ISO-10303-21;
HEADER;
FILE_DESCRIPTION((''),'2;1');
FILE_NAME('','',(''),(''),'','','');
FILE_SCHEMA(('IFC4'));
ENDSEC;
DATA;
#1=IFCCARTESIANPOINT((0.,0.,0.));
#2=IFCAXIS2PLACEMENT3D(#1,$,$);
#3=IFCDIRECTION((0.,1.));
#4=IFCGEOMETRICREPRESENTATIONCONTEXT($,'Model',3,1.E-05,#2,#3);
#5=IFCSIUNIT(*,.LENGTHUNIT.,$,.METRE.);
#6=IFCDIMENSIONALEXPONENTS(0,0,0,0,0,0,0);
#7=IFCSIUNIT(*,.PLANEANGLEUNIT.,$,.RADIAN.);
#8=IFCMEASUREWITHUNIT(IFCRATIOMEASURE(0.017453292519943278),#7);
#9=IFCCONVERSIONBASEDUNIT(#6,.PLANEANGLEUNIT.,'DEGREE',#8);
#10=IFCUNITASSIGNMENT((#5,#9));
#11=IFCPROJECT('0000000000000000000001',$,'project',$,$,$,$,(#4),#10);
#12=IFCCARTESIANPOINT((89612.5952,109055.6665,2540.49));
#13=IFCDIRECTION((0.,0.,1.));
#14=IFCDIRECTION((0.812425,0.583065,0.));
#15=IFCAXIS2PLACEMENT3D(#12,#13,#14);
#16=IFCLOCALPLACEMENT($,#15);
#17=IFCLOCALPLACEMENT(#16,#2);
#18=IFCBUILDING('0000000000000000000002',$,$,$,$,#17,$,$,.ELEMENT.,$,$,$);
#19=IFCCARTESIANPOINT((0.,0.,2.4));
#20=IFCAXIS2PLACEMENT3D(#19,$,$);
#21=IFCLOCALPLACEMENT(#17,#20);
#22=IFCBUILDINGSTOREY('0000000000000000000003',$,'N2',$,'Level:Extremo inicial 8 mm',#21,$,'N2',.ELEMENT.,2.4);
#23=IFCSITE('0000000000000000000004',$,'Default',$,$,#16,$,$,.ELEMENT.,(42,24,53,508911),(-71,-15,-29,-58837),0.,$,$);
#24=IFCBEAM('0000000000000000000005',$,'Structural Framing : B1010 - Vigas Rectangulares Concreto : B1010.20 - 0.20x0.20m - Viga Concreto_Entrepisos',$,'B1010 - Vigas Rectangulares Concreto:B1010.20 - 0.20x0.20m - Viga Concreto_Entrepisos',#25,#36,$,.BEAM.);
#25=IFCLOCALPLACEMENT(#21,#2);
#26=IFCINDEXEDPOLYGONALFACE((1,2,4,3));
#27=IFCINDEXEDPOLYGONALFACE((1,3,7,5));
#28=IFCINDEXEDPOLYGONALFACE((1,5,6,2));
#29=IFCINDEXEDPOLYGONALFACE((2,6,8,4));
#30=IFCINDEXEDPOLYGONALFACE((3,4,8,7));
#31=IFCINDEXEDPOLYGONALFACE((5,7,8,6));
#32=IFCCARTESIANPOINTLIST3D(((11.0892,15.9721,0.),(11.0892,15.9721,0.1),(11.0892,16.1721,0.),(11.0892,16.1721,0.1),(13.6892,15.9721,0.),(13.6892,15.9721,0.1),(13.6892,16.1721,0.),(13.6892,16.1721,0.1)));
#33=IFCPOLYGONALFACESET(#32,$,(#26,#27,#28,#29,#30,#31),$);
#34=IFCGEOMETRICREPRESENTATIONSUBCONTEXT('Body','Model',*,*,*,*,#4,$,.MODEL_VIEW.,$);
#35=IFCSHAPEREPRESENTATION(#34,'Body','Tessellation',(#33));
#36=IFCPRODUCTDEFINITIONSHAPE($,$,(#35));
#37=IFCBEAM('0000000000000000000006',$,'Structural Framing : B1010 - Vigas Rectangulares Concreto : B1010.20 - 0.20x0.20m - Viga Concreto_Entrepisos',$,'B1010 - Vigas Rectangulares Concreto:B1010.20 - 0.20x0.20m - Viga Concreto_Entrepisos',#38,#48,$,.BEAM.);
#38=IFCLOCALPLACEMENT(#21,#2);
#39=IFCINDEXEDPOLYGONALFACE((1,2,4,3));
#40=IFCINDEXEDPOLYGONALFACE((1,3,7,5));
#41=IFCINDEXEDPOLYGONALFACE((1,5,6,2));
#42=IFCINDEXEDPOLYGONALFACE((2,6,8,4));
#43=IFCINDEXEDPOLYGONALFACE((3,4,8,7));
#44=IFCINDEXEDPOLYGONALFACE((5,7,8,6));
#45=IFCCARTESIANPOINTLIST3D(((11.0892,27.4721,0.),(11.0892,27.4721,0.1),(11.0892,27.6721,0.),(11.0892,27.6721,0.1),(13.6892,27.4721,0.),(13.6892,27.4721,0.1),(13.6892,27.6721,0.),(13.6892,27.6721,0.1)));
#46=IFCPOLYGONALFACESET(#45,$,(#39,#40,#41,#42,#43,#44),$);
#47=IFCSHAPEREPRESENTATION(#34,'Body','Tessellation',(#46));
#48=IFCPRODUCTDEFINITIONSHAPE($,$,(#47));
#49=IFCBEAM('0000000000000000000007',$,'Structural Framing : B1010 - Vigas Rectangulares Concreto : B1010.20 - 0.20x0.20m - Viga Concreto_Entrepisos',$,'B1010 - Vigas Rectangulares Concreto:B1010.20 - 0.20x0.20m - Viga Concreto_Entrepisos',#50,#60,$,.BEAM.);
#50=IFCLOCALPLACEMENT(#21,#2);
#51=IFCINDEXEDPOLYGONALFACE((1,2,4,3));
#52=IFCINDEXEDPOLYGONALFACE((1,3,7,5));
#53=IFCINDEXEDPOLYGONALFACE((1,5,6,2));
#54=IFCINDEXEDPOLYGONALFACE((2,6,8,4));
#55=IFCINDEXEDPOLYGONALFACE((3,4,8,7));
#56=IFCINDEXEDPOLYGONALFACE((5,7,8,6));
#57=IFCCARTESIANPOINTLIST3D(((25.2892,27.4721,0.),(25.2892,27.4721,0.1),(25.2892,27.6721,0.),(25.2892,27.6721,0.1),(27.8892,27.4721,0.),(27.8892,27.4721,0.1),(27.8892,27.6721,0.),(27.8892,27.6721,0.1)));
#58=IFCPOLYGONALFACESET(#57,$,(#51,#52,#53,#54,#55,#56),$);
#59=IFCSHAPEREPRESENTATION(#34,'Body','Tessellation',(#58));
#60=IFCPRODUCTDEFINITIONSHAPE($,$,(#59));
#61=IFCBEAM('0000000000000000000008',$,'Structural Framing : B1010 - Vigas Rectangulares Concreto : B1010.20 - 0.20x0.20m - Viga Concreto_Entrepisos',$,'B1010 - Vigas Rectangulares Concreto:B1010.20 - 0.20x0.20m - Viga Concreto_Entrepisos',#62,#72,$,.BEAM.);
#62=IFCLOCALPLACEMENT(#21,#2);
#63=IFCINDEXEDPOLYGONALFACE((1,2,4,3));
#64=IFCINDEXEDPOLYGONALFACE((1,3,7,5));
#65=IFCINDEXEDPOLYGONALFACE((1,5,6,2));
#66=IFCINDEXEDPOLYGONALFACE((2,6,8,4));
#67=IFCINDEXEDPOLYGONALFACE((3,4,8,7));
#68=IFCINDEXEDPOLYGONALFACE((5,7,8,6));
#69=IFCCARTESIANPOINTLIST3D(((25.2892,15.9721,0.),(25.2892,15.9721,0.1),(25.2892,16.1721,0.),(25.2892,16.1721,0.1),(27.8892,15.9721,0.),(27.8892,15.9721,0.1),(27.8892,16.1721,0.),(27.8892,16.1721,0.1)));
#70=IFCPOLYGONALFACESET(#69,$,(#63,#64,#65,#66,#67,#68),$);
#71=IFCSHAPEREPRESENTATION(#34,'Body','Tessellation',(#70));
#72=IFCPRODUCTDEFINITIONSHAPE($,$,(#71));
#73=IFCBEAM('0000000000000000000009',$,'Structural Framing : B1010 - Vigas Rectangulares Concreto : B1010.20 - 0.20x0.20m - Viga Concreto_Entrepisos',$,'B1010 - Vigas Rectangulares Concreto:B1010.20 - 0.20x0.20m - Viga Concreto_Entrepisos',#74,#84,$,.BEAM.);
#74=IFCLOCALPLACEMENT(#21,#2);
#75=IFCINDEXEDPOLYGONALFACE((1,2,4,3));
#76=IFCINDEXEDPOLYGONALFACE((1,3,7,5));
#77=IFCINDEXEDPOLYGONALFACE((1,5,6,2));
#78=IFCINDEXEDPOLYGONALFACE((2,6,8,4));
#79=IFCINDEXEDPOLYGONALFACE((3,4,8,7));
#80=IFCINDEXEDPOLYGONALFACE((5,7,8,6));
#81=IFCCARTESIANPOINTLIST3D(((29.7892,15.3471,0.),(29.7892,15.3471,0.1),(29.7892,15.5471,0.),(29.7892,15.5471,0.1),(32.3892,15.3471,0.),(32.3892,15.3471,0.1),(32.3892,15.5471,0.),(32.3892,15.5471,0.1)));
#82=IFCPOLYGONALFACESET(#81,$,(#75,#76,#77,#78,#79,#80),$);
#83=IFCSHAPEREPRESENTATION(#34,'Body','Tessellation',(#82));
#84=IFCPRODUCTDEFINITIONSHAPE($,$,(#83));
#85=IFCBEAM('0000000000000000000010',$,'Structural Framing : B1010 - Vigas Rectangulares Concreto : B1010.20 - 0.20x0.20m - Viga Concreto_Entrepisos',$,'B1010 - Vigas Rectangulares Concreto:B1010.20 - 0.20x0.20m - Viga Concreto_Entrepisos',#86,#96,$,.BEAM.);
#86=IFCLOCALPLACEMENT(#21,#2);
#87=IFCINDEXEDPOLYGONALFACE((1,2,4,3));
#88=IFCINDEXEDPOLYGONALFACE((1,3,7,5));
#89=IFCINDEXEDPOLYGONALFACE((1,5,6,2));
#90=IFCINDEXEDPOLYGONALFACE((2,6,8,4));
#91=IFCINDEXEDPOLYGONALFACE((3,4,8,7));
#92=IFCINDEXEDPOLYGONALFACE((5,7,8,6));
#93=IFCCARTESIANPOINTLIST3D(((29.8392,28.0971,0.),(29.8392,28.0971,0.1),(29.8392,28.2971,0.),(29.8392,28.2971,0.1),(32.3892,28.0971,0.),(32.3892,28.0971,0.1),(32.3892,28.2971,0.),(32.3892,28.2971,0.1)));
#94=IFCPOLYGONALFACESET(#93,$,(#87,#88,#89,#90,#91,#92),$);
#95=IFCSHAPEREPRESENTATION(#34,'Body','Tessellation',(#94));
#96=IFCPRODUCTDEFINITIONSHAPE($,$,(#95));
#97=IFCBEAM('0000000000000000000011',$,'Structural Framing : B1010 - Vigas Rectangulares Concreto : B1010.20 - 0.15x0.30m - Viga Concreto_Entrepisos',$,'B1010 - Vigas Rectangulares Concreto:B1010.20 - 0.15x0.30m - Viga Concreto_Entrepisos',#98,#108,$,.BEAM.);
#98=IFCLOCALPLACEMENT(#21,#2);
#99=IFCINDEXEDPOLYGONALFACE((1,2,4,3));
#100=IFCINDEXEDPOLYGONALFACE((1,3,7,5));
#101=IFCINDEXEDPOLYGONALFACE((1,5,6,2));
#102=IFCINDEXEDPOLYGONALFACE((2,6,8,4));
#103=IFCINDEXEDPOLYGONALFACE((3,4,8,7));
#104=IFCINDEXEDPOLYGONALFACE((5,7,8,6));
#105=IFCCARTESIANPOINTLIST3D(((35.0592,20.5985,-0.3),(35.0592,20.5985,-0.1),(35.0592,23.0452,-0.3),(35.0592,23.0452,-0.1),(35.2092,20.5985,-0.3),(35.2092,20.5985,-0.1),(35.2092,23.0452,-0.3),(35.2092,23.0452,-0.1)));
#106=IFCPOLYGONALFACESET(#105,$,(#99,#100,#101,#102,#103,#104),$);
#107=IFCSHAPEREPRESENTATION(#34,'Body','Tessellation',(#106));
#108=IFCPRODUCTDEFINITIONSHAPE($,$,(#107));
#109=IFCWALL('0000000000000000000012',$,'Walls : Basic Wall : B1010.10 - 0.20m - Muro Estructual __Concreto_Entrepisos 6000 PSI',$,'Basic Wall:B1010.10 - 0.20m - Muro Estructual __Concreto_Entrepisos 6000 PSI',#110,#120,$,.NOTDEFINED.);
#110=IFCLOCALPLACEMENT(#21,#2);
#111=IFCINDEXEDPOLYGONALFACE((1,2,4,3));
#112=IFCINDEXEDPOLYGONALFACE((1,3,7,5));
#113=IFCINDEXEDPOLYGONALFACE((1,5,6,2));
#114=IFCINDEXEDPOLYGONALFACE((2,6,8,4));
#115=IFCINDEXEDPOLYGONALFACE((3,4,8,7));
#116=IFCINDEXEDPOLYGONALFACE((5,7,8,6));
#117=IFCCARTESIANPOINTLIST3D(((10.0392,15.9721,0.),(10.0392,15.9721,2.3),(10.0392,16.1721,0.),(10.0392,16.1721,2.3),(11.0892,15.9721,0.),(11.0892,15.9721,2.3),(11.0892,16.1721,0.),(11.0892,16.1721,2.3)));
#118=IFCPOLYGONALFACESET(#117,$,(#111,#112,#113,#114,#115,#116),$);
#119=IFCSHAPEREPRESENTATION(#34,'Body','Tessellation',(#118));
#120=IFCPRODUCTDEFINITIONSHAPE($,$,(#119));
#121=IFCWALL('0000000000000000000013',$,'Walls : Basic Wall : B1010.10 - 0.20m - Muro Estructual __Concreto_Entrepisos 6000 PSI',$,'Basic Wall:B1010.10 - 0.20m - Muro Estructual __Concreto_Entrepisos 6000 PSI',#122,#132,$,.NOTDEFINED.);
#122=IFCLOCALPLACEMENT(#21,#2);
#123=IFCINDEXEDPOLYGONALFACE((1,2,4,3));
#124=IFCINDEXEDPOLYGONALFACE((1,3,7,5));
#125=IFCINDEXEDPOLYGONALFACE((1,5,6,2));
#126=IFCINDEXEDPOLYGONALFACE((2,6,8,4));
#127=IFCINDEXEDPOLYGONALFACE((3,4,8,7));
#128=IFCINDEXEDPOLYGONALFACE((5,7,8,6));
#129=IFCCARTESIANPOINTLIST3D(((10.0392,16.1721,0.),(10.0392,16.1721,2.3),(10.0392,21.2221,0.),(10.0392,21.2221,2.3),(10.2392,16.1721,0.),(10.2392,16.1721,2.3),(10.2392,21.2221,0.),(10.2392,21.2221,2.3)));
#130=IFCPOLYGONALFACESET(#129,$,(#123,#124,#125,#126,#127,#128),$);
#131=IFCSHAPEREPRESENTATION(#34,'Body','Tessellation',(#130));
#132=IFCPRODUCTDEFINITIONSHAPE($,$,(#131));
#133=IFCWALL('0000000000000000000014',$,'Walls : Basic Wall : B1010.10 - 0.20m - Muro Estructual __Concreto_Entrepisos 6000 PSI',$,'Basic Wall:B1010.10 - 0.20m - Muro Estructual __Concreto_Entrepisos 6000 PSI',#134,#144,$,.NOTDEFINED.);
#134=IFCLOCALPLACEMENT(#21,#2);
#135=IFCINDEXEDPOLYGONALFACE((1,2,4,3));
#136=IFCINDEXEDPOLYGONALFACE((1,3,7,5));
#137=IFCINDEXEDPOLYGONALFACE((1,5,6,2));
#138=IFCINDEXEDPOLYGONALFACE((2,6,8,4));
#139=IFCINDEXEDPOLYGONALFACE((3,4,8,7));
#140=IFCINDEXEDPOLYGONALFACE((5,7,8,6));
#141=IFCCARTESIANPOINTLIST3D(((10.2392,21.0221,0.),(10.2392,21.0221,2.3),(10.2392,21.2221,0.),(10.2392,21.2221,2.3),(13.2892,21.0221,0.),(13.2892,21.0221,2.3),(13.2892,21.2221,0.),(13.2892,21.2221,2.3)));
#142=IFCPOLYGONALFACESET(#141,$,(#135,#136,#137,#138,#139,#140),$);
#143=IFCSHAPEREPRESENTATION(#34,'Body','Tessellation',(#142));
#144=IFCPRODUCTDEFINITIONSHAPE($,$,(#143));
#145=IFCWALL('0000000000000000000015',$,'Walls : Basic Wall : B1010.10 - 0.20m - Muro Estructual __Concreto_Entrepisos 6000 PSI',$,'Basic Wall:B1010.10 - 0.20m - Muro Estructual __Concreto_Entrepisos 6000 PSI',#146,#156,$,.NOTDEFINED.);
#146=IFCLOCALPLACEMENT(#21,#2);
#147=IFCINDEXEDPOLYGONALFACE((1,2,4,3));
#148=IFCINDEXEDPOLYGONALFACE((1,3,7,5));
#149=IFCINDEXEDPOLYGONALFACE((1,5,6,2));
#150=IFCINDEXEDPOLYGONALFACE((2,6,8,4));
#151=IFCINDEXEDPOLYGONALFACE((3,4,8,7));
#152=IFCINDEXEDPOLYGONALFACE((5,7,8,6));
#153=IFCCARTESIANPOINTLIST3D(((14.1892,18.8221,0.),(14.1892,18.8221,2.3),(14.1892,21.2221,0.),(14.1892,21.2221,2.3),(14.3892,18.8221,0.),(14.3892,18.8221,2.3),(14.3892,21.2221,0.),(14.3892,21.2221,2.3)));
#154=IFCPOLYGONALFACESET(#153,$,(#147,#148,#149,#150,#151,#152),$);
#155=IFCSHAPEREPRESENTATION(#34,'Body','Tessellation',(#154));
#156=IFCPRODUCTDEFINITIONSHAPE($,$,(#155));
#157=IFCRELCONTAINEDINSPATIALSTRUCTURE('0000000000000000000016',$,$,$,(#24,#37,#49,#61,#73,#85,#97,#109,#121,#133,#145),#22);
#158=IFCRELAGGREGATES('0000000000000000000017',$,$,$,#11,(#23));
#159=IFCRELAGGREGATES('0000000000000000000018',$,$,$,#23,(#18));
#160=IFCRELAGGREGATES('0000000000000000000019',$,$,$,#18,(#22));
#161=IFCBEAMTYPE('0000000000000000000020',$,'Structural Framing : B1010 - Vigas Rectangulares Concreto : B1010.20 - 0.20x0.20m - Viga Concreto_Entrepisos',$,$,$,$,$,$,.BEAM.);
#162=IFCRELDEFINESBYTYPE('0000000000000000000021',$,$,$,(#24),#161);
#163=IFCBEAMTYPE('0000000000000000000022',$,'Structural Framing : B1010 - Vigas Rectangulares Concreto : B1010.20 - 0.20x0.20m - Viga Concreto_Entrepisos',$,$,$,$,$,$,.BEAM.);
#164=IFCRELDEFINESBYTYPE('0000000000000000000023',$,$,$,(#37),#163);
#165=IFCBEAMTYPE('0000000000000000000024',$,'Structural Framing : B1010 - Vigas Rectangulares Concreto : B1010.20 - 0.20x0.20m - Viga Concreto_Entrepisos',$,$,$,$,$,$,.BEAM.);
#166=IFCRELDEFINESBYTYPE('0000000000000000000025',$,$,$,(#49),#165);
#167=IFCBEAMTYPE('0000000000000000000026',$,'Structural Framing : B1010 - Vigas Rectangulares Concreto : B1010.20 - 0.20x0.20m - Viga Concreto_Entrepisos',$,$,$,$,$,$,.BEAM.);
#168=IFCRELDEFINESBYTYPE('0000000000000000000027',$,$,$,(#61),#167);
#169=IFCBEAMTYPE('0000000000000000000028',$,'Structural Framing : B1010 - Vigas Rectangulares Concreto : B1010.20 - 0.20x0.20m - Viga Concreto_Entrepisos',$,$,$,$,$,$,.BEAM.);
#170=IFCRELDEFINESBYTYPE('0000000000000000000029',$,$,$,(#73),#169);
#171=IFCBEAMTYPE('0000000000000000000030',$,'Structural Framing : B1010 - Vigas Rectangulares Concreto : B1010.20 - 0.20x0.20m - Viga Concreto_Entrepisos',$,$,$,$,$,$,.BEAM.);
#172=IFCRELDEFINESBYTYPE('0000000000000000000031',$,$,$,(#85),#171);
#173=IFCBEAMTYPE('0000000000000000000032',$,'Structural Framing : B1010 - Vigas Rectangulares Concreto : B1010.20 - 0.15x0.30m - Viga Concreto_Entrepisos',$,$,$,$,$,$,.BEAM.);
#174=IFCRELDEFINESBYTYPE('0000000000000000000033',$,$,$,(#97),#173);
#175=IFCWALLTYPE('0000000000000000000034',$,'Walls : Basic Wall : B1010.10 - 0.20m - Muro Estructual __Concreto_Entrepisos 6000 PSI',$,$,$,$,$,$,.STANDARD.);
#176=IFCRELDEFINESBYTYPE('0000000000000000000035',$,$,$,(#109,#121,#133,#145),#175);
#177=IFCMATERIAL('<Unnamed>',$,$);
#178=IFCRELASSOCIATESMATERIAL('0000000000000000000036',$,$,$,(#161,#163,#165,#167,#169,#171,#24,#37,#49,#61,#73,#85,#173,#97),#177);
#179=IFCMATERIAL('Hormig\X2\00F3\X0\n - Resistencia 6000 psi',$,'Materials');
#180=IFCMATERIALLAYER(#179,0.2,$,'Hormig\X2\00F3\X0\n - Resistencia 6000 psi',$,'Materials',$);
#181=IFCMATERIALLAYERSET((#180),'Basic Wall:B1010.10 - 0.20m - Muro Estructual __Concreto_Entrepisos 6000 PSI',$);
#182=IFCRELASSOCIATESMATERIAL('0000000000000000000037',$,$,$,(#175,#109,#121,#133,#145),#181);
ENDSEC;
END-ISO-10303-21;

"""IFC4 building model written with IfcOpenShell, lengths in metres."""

from ifc_helpers import new_model, entity, si_unit, converted_unit, direction, frame, frame_2d, origin, place, context, subcontext, project, spatial, polyline, segment, composite_curve, rectangle, outline, extrude, source, transform, mapped, material, layer, layer_set, layer_usage, material_profile, profile_set, profile_usage, type_object, type_shapes, element, save


model = new_model("IFC4")

# Units and contexts
model_context = context("Model", 3, precision=1e-05, world=origin(), true_north=direction((0.0, 1.0)))
body_context = subcontext(model_context, "Body", "Model", "MODEL_VIEW")
ifc_project = project(units=[si_unit("LENGTHUNIT", "METRE"), converted_unit("PLANEANGLEUNIT", "DEGREE", entity("IfcRatioMeasure", 0.017453292519943278), si_unit("PLANEANGLEUNIT", "RADIAN"), dimensions=[0, 0, 0, 0, 0, 0, 0])], contexts=[model_context])

# Site, building, storey
site_placement = place(None, frame((89612.5952, 109055.6665, 2540.49), z_axis=(0.0, 0.0, 1.0), x_axis=(0.812425, 0.583065, 0.0)))
site = spatial("IfcSite", under=ifc_project, at=site_placement, Name="Default", CompositionType="ELEMENT", RefLatitude=(42, 24, 53, 508911), RefLongitude=(-71, -15, -29, -58837), RefElevation=0.0)
building_placement = place(site_placement, origin())
building = spatial("IfcBuilding", under=site, at=building_placement, CompositionType="ELEMENT")
storey_placement = place(building_placement, frame((0.0, 0.0, 2.4)))
storey = spatial("IfcBuildingStorey", under=building, at=storey_placement, Name="N2", ObjectType="Level:Extremo inicial 8 mm", LongName="N2", CompositionType="ELEMENT", Elevation=2.4)

# Beams
ifc_material_1 = material(Name="<Unnamed>")
ifc_material_profile_1 = material_profile(ifc_material_1, outline(composite_curve([segment(polyline([(-0.1, 0.0, 0.0), (-0.1, 0.1, 0.0)]), True, "CONTINUOUS"), segment(polyline([(-0.1, 0.1, 0.0), (0.1, 0.1, 0.0)]), True, "CONTINUOUS"), segment(polyline([(0.1, 0.1, 0.0), (0.1, 0.0, 0.0)]), True, "CONTINUOUS"), segment(polyline([(0.1, 0.0, 0.0), (-0.1, 0.0, 0.0)]), True, "CONTINUOUS")], self_intersect=False), kind="CURVE"), Name="B1010.20 - 0.20x0.20m - Viga Concreto_Entrepisos")
ifc_material_profile_2 = material_profile(ifc_material_1, outline(composite_curve([segment(polyline([(-1.3, -0.1, 0.1), (-1.3, 0.1, 0.1)]), True, "CONTINUOUS"), segment(polyline([(-1.3, 0.1, 0.1), (-1.3, 0.1, -0.1)]), True, "CONTINUOUS"), segment(polyline([(-1.3, 0.1, -0.1), (-1.3, -0.1, -0.1)]), True, "CONTINUOUS"), segment(polyline([(-1.3, -0.1, -0.1), (-1.3, -0.1, 0.1)]), True, "CONTINUOUS")], self_intersect=False), kind="CURVE"), Name="B1010.20 - 0.20x0.20m - Viga Concreto_Entrepisos")
ifc_profile_set_1 = profile_set([ifc_material_profile_1, ifc_material_profile_2], Name="B1010.20 - 0.20x0.20m - Viga Concreto_Entrepisos")
ifc_profile_usage_1 = profile_usage(ifc_profile_set_1, cardinal=8)
beam_type_1 = type_object("IfcBeamType", Name="Structural Framing : B1010 - Vigas Rectangulares Concreto : B1010.20 - 0.20x0.20m - Viga Concreto_Entrepisos", PredefinedType="BEAM", material=ifc_profile_set_1)
shared_shape_1 = source(origin(), body_context, "Body", "SweptSolid", [
    extrude(rectangle(XDim=0.1, YDim=0.2, at=frame_2d((0.0, 0.0), x_axis=(1.0, 0.0))), frame((13.6892, 16.0721, 2.45), z_axis=(-1.0, 0.0, 0.0), x_axis=(0.0, 0.0, -1.0)), (0.0, 0.0, 1.0), 2.6),
])
type_shapes(beam_type_1, [shared_shape_1])
beam_1_placement = place(storey_placement, frame((0.0, 0.0, -2.4)))
element("IfcBeam", 1, at=beam_1_placement, inside=storey, type_object=beam_type_1, material=ifc_profile_usage_1, Name="Structural Framing : B1010 - Vigas Rectangulares Concreto : B1010.20 - 0.20x0.20m - Viga Concreto_Entrepisos", ObjectType="B1010 - Vigas Rectangulares Concreto:B1010.20 - 0.20x0.20m - Viga Concreto_Entrepisos", PredefinedType="BEAM", context=body_context, shape_type="MappedRepresentation", body=[
    mapped(shared_shape_1, transform((0.0, 0.0, 0.0), scale=1.0)),
])
ifc_profile_usage_2 = profile_usage(ifc_profile_set_1, cardinal=8)
beam_type_2 = type_object("IfcBeamType", Name="Structural Framing : B1010 - Vigas Rectangulares Concreto : B1010.20 - 0.20x0.20m - Viga Concreto_Entrepisos", PredefinedType="BEAM", material=ifc_profile_set_1)
shared_shape_2 = source(origin(), body_context, "Body", "SweptSolid", [
    extrude(rectangle(XDim=0.1, YDim=0.2, at=frame_2d((0.0, 0.0), x_axis=(1.0, 0.0))), frame((13.6892, 27.5721, 2.45), z_axis=(-1.0, 0.0, 0.0), x_axis=(0.0, 0.0, -1.0)), (0.0, 0.0, 1.0), 2.6),
])
type_shapes(beam_type_2, [shared_shape_2])
beam_2_placement = place(storey_placement, frame((0.0, 0.0, -2.4)))
element("IfcBeam", 2, at=beam_2_placement, inside=storey, type_object=beam_type_2, material=ifc_profile_usage_2, Name="Structural Framing : B1010 - Vigas Rectangulares Concreto : B1010.20 - 0.20x0.20m - Viga Concreto_Entrepisos", ObjectType="B1010 - Vigas Rectangulares Concreto:B1010.20 - 0.20x0.20m - Viga Concreto_Entrepisos", PredefinedType="BEAM", context=body_context, shape_type="MappedRepresentation", body=[
    mapped(shared_shape_2, transform((0.0, 0.0, 0.0), scale=1.0)),
])
ifc_profile_usage_3 = profile_usage(ifc_profile_set_1, cardinal=8)
beam_type_3 = type_object("IfcBeamType", Name="Structural Framing : B1010 - Vigas Rectangulares Concreto : B1010.20 - 0.20x0.20m - Viga Concreto_Entrepisos", PredefinedType="BEAM", material=ifc_profile_set_1)
shared_shape_3 = source(origin(), body_context, "Body", "SweptSolid", [
    extrude(rectangle(XDim=0.1, YDim=0.2, at=frame_2d((0.0, 0.0), x_axis=(1.0, 0.0))), frame((25.2892, 27.5721, 2.45), z_axis=(1.0, 0.0, 0.0), x_axis=(0.0, 0.0, -1.0)), (0.0, 0.0, 1.0), 2.6),
])
type_shapes(beam_type_3, [shared_shape_3])
beam_3_placement = place(storey_placement, frame((0.0, 0.0, -2.4)))
element("IfcBeam", 3, at=beam_3_placement, inside=storey, type_object=beam_type_3, material=ifc_profile_usage_3, Name="Structural Framing : B1010 - Vigas Rectangulares Concreto : B1010.20 - 0.20x0.20m - Viga Concreto_Entrepisos", ObjectType="B1010 - Vigas Rectangulares Concreto:B1010.20 - 0.20x0.20m - Viga Concreto_Entrepisos", PredefinedType="BEAM", context=body_context, shape_type="MappedRepresentation", body=[
    mapped(shared_shape_3, transform((0.0, 0.0, 0.0), scale=1.0)),
])
ifc_profile_usage_4 = profile_usage(ifc_profile_set_1, cardinal=8)
beam_type_4 = type_object("IfcBeamType", Name="Structural Framing : B1010 - Vigas Rectangulares Concreto : B1010.20 - 0.20x0.20m - Viga Concreto_Entrepisos", PredefinedType="BEAM", material=ifc_profile_set_1)
shared_shape_4 = source(origin(), body_context, "Body", "SweptSolid", [
    extrude(rectangle(XDim=0.1, YDim=0.2, at=frame_2d((0.0, 0.0), x_axis=(1.0, 0.0))), frame((25.2892, 16.0721, 2.45), z_axis=(1.0, 0.0, 0.0), x_axis=(0.0, 0.0, -1.0)), (0.0, 0.0, 1.0), 2.6),
])
type_shapes(beam_type_4, [shared_shape_4])
beam_4_placement = place(storey_placement, frame((0.0, 0.0, -2.4)))
element("IfcBeam", 4, at=beam_4_placement, inside=storey, type_object=beam_type_4, material=ifc_profile_usage_4, Name="Structural Framing : B1010 - Vigas Rectangulares Concreto : B1010.20 - 0.20x0.20m - Viga Concreto_Entrepisos", ObjectType="B1010 - Vigas Rectangulares Concreto:B1010.20 - 0.20x0.20m - Viga Concreto_Entrepisos", PredefinedType="BEAM", context=body_context, shape_type="MappedRepresentation", body=[
    mapped(shared_shape_4, transform((0.0, 0.0, 0.0), scale=1.0)),
])
ifc_profile_usage_5 = profile_usage(ifc_profile_set_1, cardinal=8)
beam_type_5 = type_object("IfcBeamType", Name="Structural Framing : B1010 - Vigas Rectangulares Concreto : B1010.20 - 0.20x0.20m - Viga Concreto_Entrepisos", PredefinedType="BEAM", material=ifc_profile_set_1)
shared_shape_5 = source(origin(), body_context, "Body", "SweptSolid", [
    extrude(rectangle(XDim=0.1, YDim=0.2, at=frame_2d((0.0, 0.0), x_axis=(1.0, 0.0))), frame((32.3892, 15.4471, 2.45), z_axis=(-1.0, 0.0, 0.0), x_axis=(0.0, 0.0, -1.0)), (0.0, 0.0, 1.0), 2.6),
])
type_shapes(beam_type_5, [shared_shape_5])
beam_5_placement = place(storey_placement, frame((0.0, 0.0, -2.4)))
element("IfcBeam", 5, at=beam_5_placement, inside=storey, type_object=beam_type_5, material=ifc_profile_usage_5, Name="Structural Framing : B1010 - Vigas Rectangulares Concreto : B1010.20 - 0.20x0.20m - Viga Concreto_Entrepisos", ObjectType="B1010 - Vigas Rectangulares Concreto:B1010.20 - 0.20x0.20m - Viga Concreto_Entrepisos", PredefinedType="BEAM", context=body_context, shape_type="MappedRepresentation", body=[
    mapped(shared_shape_5, transform((0.0, 0.0, 0.0), scale=1.0)),
])
ifc_profile_usage_6 = profile_usage(ifc_profile_set_1, cardinal=8)
beam_type_6 = type_object("IfcBeamType", Name="Structural Framing : B1010 - Vigas Rectangulares Concreto : B1010.20 - 0.20x0.20m - Viga Concreto_Entrepisos", PredefinedType="BEAM", material=ifc_profile_set_1)
shared_shape_6 = source(origin(), body_context, "Body", "SweptSolid", [
    extrude(rectangle(XDim=0.1, YDim=0.2, at=frame_2d((0.0, 0.0), x_axis=(1.0, 0.0))), frame((29.8392, 28.1971, 2.45), z_axis=(1.0, 0.0, 0.0), x_axis=(0.0, 0.0, -1.0)), (0.0, 0.0, 1.0), 2.55),
])
type_shapes(beam_type_6, [shared_shape_6])
beam_6_placement = place(storey_placement, frame((0.0, 0.0, -2.4)))
element("IfcBeam", 6, at=beam_6_placement, inside=storey, type_object=beam_type_6, material=ifc_profile_usage_6, Name="Structural Framing : B1010 - Vigas Rectangulares Concreto : B1010.20 - 0.20x0.20m - Viga Concreto_Entrepisos", ObjectType="B1010 - Vigas Rectangulares Concreto:B1010.20 - 0.20x0.20m - Viga Concreto_Entrepisos", PredefinedType="BEAM", context=body_context, shape_type="MappedRepresentation", body=[
    mapped(shared_shape_6, transform((0.0, 0.0, 0.0), scale=1.0)),
])
ifc_material_profile_3 = material_profile(ifc_material_1, outline(composite_curve([segment(polyline([(-0.075, -0.15, 0.0), (-0.075, 0.15, 0.0)]), True, "CONTINUOUS"), segment(polyline([(-0.075, 0.15, 0.0), (0.075, 0.15, 0.0)]), True, "CONTINUOUS"), segment(polyline([(0.075, 0.15, 0.0), (0.075, -0.15, 0.0)]), True, "CONTINUOUS"), segment(polyline([(0.075, -0.15, 0.0), (-0.075, -0.15, 0.0)]), True, "CONTINUOUS")], self_intersect=False), kind="CURVE"), Name="B1010.20 - 0.15x0.30m - Viga Concreto_Entrepisos")
ifc_material_profile_4 = material_profile(ifc_material_1, outline(composite_curve([segment(polyline([(1.2233, 0.075, 0.15), (1.2233, 0.075, -0.15)]), True, "CONTINUOUS"), segment(polyline([(1.2233, 0.075, -0.15), (-1.2233, 0.075, -0.15)]), True, "CONTINUOUS"), segment(polyline([(-1.2233, 0.075, -0.15), (-1.2233, 0.075, 0.15)]), True, "CONTINUOUS"), segment(polyline([(-1.2233, 0.075, 0.15), (1.2233, 0.075, 0.15)]), True, "CONTINUOUS")], self_intersect=False), kind="CURVE"), Name="B1010.20 - 0.15x0.30m - Viga Concreto_Entrepisos")
ifc_profile_set_2 = profile_set([ifc_material_profile_3, ifc_material_profile_4], Name="B1010.20 - 0.15x0.30m - Viga Concreto_Entrepisos")
ifc_profile_usage_7 = profile_usage(ifc_profile_set_2, cardinal=8)
beam_type_7 = type_object("IfcBeamType", Name="Structural Framing : B1010 - Vigas Rectangulares Concreto : B1010.20 - 0.15x0.30m - Viga Concreto_Entrepisos", PredefinedType="BEAM", material=ifc_profile_set_2)
shared_shape_7 = source(origin(), body_context, "Body", "SweptSolid", [
    extrude(rectangle(XDim=0.2, YDim=0.15, at=frame_2d((0.0, 0.0), x_axis=(0.0, 1.0))), frame((35.1342, 20.5985, 2.2), z_axis=(0.0, 1.0, 0.0), x_axis=(-1.0, 0.0, 0.0)), (0.0, 0.0, 1.0), 2.4467),
])
type_shapes(beam_type_7, [shared_shape_7])
beam_7_placement = place(storey_placement, frame((0.0, 0.0, -2.4)))
element("IfcBeam", 7, at=beam_7_placement, inside=storey, type_object=beam_type_7, material=ifc_profile_usage_7, Name="Structural Framing : B1010 - Vigas Rectangulares Concreto : B1010.20 - 0.15x0.30m - Viga Concreto_Entrepisos", ObjectType="B1010 - Vigas Rectangulares Concreto:B1010.20 - 0.15x0.30m - Viga Concreto_Entrepisos", PredefinedType="BEAM", context=body_context, shape_type="MappedRepresentation", body=[
    mapped(shared_shape_7, transform((0.0, 0.0, 0.0), scale=1.0)),
])

# Walls
ifc_material_2 = material(Name="Hormigón - Resistencia 6000 psi", Category="Materials")
ifc_layer_1 = layer(ifc_material_2, 0.2, Name="Hormigón - Resistencia 6000 psi", Category="Materials")
ifc_layer_set_1 = layer_set([ifc_layer_1], Name="Basic Wall:B1010.10 - 0.20m - Muro Estructual __Concreto_Entrepisos 6000 PSI")
ifc_layer_usage_1 = layer_usage(ifc_layer_set_1, "AXIS2", "NEGATIVE", 0.1)
wall_type_1 = type_object("IfcWallType", Name="Walls : Basic Wall : B1010.10 - 0.20m - Muro Estructual __Concreto_Entrepisos 6000 PSI", PredefinedType="STANDARD", material=ifc_layer_set_1)
wall_1_placement = place(storey_placement, frame((11.0892, 16.0721, 0.0), z_axis=(0.0, 0.0, 1.0), x_axis=(-1.0, 0.0, 0.0)))
element("IfcWall", 8, at=wall_1_placement, inside=storey, type_object=wall_type_1, material=ifc_layer_usage_1, Name="Walls : Basic Wall : B1010.10 - 0.20m - Muro Estructual __Concreto_Entrepisos 6000 PSI", ObjectType="Basic Wall:B1010.10 - 0.20m - Muro Estructual __Concreto_Entrepisos 6000 PSI", PredefinedType="NOTDEFINED", context=body_context, shape_type="SweptSolid", body=[
    extrude(rectangle(XDim=1.05, YDim=0.2, at=frame_2d((0.525, 0.0), x_axis=(-1.0, 0.0))), origin(), (0.0, 0.0, 1.0), 2.3),
])
ifc_layer_usage_2 = layer_usage(ifc_layer_set_1, "AXIS2", "NEGATIVE", 0.1)
wall_2_placement = place(storey_placement, frame((10.1392, 16.1721, 0.0), z_axis=(0.0, 0.0, 1.0), x_axis=(0.0, 1.0, 0.0)))
element("IfcWall", 9, at=wall_2_placement, inside=storey, type_object=wall_type_1, material=ifc_layer_usage_2, Name="Walls : Basic Wall : B1010.10 - 0.20m - Muro Estructual __Concreto_Entrepisos 6000 PSI", ObjectType="Basic Wall:B1010.10 - 0.20m - Muro Estructual __Concreto_Entrepisos 6000 PSI", PredefinedType="NOTDEFINED", context=body_context, shape_type="SweptSolid", body=[
    extrude(rectangle(XDim=5.05, YDim=0.2, at=frame_2d((2.525, 0.0), x_axis=(-1.0, 0.0))), origin(), (0.0, 0.0, 1.0), 2.3),
])
ifc_layer_usage_3 = layer_usage(ifc_layer_set_1, "AXIS2", "NEGATIVE", 0.1)
wall_3_placement = place(storey_placement, frame((10.2392, 21.1221, 0.0)))
element("IfcWall", 10, at=wall_3_placement, inside=storey, type_object=wall_type_1, material=ifc_layer_usage_3, Name="Walls : Basic Wall : B1010.10 - 0.20m - Muro Estructual __Concreto_Entrepisos 6000 PSI", ObjectType="Basic Wall:B1010.10 - 0.20m - Muro Estructual __Concreto_Entrepisos 6000 PSI", PredefinedType="NOTDEFINED", context=body_context, shape_type="SweptSolid", body=[
    extrude(rectangle(XDim=3.05, YDim=0.2, at=frame_2d((1.525, 0.0), x_axis=(-1.0, 0.0))), origin(), (0.0, 0.0, 1.0), 2.3),
])
ifc_layer_usage_4 = layer_usage(ifc_layer_set_1, "AXIS2", "NEGATIVE", 0.1)
wall_4_placement = place(storey_placement, frame((14.2892, 18.8221, 0.0), z_axis=(0.0, 0.0, 1.0), x_axis=(0.0, 1.0, 0.0)))
element("IfcWall", 11, at=wall_4_placement, inside=storey, type_object=wall_type_1, material=ifc_layer_usage_4, Name="Walls : Basic Wall : B1010.10 - 0.20m - Muro Estructual __Concreto_Entrepisos 6000 PSI", ObjectType="Basic Wall:B1010.10 - 0.20m - Muro Estructual __Concreto_Entrepisos 6000 PSI", PredefinedType="NOTDEFINED", context=body_context, shape_type="SweptSolid", body=[
    extrude(rectangle(XDim=2.4, YDim=0.2, at=frame_2d((1.2, 0.0), x_axis=(-1.0, 0.0))), origin(), (0.0, 0.0, 1.0), 2.3),
])

save(model, "model.ifc")
